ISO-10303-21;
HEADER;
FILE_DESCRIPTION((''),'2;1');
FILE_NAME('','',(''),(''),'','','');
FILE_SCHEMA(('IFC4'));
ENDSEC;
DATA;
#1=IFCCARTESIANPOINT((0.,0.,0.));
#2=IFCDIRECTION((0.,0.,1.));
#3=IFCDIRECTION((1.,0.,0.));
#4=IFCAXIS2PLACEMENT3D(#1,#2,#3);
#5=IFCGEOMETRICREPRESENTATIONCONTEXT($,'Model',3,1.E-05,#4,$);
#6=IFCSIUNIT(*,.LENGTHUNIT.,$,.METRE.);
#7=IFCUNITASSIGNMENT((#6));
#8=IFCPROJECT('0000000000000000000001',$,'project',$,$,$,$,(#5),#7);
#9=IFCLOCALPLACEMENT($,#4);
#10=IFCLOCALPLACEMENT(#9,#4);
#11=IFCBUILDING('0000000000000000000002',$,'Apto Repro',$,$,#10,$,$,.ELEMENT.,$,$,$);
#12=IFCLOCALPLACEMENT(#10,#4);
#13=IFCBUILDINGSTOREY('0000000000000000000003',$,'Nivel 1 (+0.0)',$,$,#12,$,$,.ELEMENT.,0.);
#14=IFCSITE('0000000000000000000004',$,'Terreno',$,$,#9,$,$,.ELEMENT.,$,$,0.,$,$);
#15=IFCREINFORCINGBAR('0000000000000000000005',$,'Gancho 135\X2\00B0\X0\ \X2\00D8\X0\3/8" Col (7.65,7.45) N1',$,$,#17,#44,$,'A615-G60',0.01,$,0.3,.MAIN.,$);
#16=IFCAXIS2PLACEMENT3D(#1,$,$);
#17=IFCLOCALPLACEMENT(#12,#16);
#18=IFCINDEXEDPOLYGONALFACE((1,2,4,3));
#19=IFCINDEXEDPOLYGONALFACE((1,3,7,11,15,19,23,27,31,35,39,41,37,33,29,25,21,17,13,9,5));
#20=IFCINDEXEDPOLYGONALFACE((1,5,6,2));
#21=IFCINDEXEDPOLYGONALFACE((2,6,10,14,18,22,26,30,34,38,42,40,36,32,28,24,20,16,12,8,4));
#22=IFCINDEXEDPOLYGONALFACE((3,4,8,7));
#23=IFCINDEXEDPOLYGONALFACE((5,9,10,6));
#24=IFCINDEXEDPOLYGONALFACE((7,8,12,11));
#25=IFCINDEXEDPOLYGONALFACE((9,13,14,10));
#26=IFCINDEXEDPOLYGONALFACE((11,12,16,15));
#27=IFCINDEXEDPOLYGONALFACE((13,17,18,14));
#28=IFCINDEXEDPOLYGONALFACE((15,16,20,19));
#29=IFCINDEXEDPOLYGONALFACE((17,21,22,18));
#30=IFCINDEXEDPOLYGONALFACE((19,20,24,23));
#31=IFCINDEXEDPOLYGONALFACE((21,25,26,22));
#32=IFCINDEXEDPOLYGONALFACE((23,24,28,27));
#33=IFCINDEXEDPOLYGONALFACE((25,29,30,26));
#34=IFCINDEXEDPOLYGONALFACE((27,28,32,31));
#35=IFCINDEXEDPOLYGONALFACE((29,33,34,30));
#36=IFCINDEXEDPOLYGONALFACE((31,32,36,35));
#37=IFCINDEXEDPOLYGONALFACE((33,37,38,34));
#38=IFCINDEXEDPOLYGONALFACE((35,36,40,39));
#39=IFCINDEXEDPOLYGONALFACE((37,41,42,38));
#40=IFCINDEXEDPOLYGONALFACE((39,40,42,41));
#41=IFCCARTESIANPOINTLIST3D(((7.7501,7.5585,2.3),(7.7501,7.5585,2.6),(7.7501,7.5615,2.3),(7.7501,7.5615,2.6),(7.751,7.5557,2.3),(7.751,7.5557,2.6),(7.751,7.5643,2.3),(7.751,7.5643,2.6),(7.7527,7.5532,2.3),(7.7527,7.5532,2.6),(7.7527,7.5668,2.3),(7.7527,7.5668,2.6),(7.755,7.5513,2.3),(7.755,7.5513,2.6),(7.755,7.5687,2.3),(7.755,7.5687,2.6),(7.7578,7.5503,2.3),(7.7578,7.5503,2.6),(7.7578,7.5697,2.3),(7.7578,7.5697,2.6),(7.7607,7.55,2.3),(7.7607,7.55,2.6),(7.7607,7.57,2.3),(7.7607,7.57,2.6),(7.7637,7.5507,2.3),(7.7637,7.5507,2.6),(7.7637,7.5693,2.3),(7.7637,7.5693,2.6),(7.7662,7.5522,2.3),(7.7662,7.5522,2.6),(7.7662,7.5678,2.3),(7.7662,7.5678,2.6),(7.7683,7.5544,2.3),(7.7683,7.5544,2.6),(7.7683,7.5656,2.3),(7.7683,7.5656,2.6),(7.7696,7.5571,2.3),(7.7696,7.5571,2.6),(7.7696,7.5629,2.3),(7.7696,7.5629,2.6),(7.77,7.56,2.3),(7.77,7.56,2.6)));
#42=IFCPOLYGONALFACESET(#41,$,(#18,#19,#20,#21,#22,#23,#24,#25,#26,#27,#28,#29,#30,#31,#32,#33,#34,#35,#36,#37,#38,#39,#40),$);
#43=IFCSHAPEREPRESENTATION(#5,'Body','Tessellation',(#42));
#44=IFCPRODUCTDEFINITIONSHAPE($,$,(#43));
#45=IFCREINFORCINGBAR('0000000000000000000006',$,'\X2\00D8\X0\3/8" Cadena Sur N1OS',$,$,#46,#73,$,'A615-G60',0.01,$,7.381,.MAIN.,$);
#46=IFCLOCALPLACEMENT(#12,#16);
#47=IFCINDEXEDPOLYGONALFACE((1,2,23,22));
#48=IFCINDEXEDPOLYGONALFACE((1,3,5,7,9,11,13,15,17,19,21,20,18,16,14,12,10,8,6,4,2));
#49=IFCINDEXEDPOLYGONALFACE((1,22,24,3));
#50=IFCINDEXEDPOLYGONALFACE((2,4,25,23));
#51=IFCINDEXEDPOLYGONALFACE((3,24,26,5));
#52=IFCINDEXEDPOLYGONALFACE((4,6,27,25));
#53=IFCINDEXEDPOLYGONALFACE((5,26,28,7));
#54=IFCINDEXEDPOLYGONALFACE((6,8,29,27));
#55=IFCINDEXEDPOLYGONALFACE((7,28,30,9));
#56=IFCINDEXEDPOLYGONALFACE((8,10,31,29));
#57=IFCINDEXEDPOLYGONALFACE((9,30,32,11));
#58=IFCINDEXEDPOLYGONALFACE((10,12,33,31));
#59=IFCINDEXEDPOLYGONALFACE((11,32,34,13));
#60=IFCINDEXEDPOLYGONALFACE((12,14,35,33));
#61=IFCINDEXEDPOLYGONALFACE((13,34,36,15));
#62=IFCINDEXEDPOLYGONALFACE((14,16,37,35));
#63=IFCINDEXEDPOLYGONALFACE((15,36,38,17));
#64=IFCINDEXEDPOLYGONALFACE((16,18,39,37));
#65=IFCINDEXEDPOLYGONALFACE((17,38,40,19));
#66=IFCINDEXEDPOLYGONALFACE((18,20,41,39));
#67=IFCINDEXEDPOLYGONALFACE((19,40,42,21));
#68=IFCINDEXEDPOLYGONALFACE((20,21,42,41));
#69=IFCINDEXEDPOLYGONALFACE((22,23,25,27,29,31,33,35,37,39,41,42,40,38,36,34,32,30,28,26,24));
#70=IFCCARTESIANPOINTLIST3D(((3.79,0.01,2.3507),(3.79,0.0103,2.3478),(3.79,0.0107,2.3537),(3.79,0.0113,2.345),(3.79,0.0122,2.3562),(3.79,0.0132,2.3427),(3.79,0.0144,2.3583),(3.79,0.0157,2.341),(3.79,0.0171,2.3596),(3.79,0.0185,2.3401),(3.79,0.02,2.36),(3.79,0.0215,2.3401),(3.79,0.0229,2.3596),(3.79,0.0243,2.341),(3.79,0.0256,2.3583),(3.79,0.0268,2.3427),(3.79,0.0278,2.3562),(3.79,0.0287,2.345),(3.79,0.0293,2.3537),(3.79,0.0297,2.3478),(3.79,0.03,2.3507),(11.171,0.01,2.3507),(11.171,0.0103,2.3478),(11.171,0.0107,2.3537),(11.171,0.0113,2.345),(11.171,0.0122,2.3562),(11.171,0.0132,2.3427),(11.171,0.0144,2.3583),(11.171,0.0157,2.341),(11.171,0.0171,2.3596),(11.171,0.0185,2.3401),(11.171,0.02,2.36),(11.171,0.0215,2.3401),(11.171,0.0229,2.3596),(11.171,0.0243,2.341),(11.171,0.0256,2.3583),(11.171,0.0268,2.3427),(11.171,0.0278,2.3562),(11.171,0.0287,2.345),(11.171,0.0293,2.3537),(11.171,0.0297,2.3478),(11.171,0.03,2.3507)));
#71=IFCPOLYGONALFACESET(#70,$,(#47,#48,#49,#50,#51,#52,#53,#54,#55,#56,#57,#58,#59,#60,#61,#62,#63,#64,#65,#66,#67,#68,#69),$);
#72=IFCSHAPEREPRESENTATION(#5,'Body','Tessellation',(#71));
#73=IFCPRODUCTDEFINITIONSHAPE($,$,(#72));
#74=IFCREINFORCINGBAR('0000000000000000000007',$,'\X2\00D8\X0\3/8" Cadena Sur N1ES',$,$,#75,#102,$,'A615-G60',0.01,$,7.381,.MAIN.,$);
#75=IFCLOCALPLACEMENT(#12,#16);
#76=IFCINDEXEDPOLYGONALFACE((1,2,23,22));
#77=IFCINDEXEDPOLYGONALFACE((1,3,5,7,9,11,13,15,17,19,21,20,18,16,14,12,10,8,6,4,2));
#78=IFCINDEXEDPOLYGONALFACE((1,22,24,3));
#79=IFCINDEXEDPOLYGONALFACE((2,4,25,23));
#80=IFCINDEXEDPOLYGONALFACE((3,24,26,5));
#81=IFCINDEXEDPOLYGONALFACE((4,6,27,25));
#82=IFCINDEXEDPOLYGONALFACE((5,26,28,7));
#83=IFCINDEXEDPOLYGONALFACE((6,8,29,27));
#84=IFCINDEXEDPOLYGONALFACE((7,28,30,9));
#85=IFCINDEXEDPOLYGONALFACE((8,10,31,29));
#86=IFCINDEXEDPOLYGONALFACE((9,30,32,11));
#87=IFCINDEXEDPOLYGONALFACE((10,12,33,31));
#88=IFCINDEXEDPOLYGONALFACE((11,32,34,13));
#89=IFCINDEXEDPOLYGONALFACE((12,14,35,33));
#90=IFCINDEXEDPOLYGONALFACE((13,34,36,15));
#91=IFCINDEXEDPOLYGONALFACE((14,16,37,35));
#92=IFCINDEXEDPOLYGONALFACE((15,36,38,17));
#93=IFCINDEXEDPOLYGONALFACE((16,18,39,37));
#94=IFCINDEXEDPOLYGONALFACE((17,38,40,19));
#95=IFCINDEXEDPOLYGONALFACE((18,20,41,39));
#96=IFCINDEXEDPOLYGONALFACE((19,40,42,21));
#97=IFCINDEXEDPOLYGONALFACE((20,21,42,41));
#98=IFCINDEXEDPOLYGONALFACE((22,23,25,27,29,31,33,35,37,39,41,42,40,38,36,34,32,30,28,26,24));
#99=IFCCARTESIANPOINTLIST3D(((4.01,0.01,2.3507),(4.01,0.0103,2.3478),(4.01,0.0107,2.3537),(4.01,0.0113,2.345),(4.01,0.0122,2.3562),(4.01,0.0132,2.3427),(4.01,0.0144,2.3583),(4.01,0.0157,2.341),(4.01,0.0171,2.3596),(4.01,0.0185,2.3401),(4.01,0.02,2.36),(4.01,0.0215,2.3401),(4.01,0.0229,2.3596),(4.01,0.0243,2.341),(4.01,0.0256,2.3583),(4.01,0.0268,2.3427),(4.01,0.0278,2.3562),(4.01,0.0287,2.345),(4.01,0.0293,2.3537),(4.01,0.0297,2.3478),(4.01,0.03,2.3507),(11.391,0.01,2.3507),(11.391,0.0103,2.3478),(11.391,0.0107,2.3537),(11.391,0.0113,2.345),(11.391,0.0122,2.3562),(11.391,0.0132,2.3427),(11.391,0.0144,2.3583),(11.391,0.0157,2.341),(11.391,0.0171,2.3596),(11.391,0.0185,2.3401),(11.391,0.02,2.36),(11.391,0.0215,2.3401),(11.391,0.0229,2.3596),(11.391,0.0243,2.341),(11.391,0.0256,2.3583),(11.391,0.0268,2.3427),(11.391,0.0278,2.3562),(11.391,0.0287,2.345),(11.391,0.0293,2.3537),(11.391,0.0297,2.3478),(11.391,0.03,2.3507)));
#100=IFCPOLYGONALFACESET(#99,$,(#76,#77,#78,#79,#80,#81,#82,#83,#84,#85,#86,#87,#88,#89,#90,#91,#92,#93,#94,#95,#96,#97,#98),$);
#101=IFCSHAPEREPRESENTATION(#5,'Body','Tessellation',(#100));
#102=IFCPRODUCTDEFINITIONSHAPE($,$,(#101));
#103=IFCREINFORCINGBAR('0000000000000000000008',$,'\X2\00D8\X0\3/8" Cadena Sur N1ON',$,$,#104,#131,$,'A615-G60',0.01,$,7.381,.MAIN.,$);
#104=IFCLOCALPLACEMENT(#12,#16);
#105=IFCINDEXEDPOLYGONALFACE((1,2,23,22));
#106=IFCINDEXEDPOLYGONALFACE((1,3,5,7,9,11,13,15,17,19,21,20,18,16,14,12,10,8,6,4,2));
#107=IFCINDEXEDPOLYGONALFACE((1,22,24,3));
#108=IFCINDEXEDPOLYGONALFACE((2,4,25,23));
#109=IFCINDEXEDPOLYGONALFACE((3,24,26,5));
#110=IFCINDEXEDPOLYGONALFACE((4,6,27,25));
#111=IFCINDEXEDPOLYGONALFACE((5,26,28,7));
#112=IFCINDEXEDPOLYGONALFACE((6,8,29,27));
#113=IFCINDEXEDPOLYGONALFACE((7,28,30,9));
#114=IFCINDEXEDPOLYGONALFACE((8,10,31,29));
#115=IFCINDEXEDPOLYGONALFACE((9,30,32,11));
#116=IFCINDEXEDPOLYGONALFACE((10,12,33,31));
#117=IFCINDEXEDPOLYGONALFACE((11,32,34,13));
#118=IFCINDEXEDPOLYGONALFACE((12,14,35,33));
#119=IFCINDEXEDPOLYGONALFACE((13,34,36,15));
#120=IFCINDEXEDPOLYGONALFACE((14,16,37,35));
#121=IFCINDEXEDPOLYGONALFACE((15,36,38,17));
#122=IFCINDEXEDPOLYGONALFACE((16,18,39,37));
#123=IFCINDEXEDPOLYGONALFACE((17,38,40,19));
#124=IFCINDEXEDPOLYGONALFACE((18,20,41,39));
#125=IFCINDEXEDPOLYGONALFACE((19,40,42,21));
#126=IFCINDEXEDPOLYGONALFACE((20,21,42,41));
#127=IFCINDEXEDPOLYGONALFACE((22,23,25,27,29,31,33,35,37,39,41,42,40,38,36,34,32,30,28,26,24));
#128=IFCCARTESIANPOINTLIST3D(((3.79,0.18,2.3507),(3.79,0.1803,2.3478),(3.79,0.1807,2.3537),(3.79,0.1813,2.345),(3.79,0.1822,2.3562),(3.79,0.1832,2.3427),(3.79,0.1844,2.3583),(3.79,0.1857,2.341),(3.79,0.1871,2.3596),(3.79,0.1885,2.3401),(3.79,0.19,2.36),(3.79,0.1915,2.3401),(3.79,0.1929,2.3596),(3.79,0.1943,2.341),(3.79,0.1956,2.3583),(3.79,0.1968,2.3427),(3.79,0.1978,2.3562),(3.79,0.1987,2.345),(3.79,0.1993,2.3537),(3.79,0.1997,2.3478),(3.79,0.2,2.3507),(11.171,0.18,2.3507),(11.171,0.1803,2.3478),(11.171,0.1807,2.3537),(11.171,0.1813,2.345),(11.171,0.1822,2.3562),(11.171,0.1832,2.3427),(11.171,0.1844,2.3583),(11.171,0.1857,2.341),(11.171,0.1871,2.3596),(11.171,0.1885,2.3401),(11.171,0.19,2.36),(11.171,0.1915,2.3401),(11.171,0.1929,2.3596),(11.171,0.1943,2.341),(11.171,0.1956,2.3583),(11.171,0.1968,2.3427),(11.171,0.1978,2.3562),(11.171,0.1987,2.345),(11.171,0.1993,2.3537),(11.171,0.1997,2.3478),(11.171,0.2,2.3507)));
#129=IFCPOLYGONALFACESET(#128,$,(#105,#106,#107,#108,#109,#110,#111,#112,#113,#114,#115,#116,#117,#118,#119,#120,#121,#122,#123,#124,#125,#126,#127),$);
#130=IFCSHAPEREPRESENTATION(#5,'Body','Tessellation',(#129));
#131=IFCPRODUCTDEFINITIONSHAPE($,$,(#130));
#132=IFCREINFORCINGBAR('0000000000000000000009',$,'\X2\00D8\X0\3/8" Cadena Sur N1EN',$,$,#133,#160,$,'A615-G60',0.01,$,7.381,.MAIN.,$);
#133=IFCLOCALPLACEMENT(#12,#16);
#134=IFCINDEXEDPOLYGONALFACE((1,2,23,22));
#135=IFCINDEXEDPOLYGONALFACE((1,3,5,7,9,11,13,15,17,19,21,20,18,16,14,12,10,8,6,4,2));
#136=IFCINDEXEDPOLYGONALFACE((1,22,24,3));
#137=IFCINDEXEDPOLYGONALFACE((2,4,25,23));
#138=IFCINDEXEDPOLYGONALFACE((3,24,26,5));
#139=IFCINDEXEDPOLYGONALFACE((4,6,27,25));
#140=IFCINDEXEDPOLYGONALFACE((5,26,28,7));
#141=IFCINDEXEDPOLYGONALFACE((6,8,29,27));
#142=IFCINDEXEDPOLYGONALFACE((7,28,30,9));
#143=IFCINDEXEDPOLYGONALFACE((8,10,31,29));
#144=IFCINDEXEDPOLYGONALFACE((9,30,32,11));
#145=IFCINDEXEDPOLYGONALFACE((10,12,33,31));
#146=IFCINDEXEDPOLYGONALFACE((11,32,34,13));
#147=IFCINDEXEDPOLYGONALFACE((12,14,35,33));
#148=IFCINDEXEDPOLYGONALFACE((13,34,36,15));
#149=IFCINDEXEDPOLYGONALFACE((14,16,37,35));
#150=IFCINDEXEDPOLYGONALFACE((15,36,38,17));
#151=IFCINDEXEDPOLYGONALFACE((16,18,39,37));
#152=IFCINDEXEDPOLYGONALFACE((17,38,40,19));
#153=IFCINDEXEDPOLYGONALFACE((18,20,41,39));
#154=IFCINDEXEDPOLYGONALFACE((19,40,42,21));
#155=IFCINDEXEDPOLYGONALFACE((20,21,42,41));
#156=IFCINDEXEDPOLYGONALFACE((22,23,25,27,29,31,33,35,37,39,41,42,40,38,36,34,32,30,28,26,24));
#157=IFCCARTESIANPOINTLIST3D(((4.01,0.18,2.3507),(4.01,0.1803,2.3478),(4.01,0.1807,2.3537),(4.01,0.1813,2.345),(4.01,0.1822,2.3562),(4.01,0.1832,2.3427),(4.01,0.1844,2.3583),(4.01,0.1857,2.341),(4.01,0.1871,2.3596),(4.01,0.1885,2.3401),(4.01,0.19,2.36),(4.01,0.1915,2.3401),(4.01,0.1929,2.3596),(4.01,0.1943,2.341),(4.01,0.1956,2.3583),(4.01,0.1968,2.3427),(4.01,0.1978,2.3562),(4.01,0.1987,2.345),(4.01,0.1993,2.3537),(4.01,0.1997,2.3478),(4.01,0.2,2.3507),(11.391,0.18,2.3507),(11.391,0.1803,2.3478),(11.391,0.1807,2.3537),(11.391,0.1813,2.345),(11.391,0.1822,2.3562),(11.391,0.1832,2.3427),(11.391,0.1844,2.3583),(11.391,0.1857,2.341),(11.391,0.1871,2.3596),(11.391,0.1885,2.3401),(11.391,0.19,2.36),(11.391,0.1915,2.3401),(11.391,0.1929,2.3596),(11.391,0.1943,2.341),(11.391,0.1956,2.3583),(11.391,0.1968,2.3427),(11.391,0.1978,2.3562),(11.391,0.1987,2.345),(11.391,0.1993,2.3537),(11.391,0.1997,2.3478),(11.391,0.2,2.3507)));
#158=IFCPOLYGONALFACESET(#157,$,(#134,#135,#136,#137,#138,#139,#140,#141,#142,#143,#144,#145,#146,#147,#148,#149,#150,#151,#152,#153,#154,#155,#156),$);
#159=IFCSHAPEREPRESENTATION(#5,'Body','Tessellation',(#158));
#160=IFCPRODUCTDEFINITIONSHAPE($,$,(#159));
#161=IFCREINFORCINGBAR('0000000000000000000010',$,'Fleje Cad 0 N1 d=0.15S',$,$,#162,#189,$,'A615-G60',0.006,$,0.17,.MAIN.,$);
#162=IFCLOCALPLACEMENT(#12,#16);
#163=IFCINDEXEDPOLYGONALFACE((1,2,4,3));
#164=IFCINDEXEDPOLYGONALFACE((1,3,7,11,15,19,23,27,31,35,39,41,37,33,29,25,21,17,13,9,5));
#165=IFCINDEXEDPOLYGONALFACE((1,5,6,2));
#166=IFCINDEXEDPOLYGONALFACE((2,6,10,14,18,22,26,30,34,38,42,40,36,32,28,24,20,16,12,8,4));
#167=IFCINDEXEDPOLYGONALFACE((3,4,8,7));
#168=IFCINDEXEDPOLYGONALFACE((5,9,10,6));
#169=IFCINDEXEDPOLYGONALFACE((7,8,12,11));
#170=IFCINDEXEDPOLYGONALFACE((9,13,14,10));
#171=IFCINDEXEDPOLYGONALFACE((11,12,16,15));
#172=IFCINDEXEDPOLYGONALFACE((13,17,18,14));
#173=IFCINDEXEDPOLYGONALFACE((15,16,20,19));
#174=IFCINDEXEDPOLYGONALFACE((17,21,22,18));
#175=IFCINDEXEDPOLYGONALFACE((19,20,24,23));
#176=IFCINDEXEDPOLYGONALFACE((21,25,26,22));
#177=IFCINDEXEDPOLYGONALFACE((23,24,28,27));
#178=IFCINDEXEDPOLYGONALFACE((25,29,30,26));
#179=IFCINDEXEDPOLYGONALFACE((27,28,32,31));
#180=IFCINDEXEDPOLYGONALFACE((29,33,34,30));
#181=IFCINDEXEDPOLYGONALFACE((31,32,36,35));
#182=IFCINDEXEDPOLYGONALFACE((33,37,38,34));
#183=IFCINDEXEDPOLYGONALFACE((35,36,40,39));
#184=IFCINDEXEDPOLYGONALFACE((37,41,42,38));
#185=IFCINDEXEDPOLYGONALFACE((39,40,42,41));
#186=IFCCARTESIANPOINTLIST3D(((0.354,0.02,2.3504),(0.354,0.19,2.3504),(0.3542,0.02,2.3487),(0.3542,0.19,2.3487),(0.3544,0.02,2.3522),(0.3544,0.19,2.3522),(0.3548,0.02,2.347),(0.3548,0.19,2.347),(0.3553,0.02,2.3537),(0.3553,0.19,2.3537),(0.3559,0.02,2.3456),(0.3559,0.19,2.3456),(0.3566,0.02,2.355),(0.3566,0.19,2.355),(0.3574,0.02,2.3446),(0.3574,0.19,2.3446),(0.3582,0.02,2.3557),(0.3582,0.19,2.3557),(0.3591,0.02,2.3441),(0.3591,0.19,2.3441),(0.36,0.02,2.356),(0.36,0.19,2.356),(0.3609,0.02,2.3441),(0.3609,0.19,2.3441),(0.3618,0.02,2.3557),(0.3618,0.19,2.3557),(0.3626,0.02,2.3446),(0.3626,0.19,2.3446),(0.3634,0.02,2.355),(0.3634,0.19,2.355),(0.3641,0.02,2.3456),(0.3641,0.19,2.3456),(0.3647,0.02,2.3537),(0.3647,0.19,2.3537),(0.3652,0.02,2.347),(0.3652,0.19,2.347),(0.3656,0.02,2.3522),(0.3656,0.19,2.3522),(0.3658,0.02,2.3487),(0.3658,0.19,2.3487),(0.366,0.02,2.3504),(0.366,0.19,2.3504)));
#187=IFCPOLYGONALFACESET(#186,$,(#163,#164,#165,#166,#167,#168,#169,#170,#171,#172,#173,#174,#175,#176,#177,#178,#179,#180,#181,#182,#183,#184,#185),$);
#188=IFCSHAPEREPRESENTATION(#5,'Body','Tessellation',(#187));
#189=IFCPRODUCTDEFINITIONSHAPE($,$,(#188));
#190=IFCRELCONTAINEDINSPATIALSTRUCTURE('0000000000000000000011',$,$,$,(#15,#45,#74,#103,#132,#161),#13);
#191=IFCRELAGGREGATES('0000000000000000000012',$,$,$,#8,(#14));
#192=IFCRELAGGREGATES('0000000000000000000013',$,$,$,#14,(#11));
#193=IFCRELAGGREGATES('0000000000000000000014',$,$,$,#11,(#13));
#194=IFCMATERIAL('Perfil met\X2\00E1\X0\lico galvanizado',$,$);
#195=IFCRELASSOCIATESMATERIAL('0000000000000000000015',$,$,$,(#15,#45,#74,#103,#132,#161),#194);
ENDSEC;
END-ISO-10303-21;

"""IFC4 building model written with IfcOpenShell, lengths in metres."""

from ifc_helpers import new_model, si_unit, frame, origin_with_axes, origin_2d_with_axis, place, context, project, spatial, circle, extrude, material, element, save


model = new_model("IFC4")

# Units and contexts
model_context = context("Model", 3, precision=1e-05, world=origin_with_axes())
ifc_project = project(units=[si_unit("LENGTHUNIT", "METRE")], contexts=[model_context])

# Site, building, storey
site_placement = place(None, origin_with_axes())
site = spatial("IfcSite", under=ifc_project, at=site_placement, Name="Terreno", CompositionType="ELEMENT", RefElevation=0.0)
building_placement = place(site_placement, origin_with_axes())
building = spatial("IfcBuilding", under=site, at=building_placement, Name="Apto Repro", CompositionType="ELEMENT")
storey_placement = place(building_placement, origin_with_axes())
storey = spatial("IfcBuildingStorey", under=building, at=storey_placement, Name="Nivel 1 (+0.0)", CompositionType="ELEMENT", Elevation=0.0)

# Reinforcing bars
ifc_material = material(Name="Perfil metálico galvanizado")
reinforcing_bar_1_placement = place(storey_placement, origin_with_axes())
element("IfcReinforcingBar", 1, at=reinforcing_bar_1_placement, inside=storey, material=ifc_material, Name="Gancho 135° Ø3/8\" Col (7.65,7.45) N1", SteelGrade="A615-G60", BarLength=0.3, NominalDiameter=0.01, PredefinedType="MAIN", context=model_context, shape_type="SweptSolid", body=[
    extrude(circle(Radius=0.01, at=origin_2d_with_axis()), frame((7.76, 7.56, 2.3), z_axis=(0.0, 0.0, 1.0), x_axis=(1.0, 0.0, 0.0)), (0.0, 0.0, 1.0), 0.3),
])
reinforcing_bar_2_placement = place(storey_placement, origin_with_axes())
element("IfcReinforcingBar", 2, at=reinforcing_bar_2_placement, inside=storey, material=ifc_material, Name="Ø3/8\" Cadena Sur N1OS", SteelGrade="A615-G60", BarLength=7.381, NominalDiameter=0.01, PredefinedType="MAIN", context=model_context, shape_type="SweptSolid", body=[
    extrude(circle(Radius=0.01, at=origin_2d_with_axis()), frame((3.79, 0.02, 2.35), z_axis=(1.0, 0.0, 0.0), x_axis=(0.0, 0.0, 1.0)), (0.0, 0.0, 1.0), 7.381),
])
reinforcing_bar_3_placement = place(storey_placement, origin_with_axes())
element("IfcReinforcingBar", 3, at=reinforcing_bar_3_placement, inside=storey, material=ifc_material, Name="Ø3/8\" Cadena Sur N1ES", SteelGrade="A615-G60", BarLength=7.381, NominalDiameter=0.01, PredefinedType="MAIN", context=model_context, shape_type="SweptSolid", body=[
    extrude(circle(Radius=0.01, at=origin_2d_with_axis()), frame((4.01, 0.02, 2.35), z_axis=(1.0, 0.0, 0.0), x_axis=(0.0, 0.0, 1.0)), (0.0, 0.0, 1.0), 7.381),
])
reinforcing_bar_4_placement = place(storey_placement, origin_with_axes())
element("IfcReinforcingBar", 4, at=reinforcing_bar_4_placement, inside=storey, material=ifc_material, Name="Ø3/8\" Cadena Sur N1ON", SteelGrade="A615-G60", BarLength=7.381, NominalDiameter=0.01, PredefinedType="MAIN", context=model_context, shape_type="SweptSolid", body=[
    extrude(circle(Radius=0.01, at=origin_2d_with_axis()), frame((3.79, 0.19, 2.35), z_axis=(1.0, 0.0, 0.0), x_axis=(0.0, 0.0, 1.0)), (0.0, 0.0, 1.0), 7.381),
])
reinforcing_bar_5_placement = place(storey_placement, origin_with_axes())
element("IfcReinforcingBar", 5, at=reinforcing_bar_5_placement, inside=storey, material=ifc_material, Name="Ø3/8\" Cadena Sur N1EN", SteelGrade="A615-G60", BarLength=7.381, NominalDiameter=0.01, PredefinedType="MAIN", context=model_context, shape_type="SweptSolid", body=[
    extrude(circle(Radius=0.01, at=origin_2d_with_axis()), frame((4.01, 0.19, 2.35), z_axis=(1.0, 0.0, 0.0), x_axis=(0.0, 0.0, 1.0)), (0.0, 0.0, 1.0), 7.381),
])
reinforcing_bar_6_placement = place(storey_placement, origin_with_axes())
element("IfcReinforcingBar", 6, at=reinforcing_bar_6_placement, inside=storey, material=ifc_material, Name="Fleje Cad 0 N1 d=0.15S", SteelGrade="A615-G60", BarLength=0.17, NominalDiameter=0.006, PredefinedType="MAIN", context=model_context, shape_type="SweptSolid", body=[
    extrude(circle(Radius=0.006, at=origin_2d_with_axis()), frame((0.36, 0.02, 2.35), z_axis=(0.0, 1.0, 0.0), x_axis=(0.0, 0.0, 1.0)), (0.0, 0.0, 1.0), 0.17),
])

save(model, "model.ifc")
